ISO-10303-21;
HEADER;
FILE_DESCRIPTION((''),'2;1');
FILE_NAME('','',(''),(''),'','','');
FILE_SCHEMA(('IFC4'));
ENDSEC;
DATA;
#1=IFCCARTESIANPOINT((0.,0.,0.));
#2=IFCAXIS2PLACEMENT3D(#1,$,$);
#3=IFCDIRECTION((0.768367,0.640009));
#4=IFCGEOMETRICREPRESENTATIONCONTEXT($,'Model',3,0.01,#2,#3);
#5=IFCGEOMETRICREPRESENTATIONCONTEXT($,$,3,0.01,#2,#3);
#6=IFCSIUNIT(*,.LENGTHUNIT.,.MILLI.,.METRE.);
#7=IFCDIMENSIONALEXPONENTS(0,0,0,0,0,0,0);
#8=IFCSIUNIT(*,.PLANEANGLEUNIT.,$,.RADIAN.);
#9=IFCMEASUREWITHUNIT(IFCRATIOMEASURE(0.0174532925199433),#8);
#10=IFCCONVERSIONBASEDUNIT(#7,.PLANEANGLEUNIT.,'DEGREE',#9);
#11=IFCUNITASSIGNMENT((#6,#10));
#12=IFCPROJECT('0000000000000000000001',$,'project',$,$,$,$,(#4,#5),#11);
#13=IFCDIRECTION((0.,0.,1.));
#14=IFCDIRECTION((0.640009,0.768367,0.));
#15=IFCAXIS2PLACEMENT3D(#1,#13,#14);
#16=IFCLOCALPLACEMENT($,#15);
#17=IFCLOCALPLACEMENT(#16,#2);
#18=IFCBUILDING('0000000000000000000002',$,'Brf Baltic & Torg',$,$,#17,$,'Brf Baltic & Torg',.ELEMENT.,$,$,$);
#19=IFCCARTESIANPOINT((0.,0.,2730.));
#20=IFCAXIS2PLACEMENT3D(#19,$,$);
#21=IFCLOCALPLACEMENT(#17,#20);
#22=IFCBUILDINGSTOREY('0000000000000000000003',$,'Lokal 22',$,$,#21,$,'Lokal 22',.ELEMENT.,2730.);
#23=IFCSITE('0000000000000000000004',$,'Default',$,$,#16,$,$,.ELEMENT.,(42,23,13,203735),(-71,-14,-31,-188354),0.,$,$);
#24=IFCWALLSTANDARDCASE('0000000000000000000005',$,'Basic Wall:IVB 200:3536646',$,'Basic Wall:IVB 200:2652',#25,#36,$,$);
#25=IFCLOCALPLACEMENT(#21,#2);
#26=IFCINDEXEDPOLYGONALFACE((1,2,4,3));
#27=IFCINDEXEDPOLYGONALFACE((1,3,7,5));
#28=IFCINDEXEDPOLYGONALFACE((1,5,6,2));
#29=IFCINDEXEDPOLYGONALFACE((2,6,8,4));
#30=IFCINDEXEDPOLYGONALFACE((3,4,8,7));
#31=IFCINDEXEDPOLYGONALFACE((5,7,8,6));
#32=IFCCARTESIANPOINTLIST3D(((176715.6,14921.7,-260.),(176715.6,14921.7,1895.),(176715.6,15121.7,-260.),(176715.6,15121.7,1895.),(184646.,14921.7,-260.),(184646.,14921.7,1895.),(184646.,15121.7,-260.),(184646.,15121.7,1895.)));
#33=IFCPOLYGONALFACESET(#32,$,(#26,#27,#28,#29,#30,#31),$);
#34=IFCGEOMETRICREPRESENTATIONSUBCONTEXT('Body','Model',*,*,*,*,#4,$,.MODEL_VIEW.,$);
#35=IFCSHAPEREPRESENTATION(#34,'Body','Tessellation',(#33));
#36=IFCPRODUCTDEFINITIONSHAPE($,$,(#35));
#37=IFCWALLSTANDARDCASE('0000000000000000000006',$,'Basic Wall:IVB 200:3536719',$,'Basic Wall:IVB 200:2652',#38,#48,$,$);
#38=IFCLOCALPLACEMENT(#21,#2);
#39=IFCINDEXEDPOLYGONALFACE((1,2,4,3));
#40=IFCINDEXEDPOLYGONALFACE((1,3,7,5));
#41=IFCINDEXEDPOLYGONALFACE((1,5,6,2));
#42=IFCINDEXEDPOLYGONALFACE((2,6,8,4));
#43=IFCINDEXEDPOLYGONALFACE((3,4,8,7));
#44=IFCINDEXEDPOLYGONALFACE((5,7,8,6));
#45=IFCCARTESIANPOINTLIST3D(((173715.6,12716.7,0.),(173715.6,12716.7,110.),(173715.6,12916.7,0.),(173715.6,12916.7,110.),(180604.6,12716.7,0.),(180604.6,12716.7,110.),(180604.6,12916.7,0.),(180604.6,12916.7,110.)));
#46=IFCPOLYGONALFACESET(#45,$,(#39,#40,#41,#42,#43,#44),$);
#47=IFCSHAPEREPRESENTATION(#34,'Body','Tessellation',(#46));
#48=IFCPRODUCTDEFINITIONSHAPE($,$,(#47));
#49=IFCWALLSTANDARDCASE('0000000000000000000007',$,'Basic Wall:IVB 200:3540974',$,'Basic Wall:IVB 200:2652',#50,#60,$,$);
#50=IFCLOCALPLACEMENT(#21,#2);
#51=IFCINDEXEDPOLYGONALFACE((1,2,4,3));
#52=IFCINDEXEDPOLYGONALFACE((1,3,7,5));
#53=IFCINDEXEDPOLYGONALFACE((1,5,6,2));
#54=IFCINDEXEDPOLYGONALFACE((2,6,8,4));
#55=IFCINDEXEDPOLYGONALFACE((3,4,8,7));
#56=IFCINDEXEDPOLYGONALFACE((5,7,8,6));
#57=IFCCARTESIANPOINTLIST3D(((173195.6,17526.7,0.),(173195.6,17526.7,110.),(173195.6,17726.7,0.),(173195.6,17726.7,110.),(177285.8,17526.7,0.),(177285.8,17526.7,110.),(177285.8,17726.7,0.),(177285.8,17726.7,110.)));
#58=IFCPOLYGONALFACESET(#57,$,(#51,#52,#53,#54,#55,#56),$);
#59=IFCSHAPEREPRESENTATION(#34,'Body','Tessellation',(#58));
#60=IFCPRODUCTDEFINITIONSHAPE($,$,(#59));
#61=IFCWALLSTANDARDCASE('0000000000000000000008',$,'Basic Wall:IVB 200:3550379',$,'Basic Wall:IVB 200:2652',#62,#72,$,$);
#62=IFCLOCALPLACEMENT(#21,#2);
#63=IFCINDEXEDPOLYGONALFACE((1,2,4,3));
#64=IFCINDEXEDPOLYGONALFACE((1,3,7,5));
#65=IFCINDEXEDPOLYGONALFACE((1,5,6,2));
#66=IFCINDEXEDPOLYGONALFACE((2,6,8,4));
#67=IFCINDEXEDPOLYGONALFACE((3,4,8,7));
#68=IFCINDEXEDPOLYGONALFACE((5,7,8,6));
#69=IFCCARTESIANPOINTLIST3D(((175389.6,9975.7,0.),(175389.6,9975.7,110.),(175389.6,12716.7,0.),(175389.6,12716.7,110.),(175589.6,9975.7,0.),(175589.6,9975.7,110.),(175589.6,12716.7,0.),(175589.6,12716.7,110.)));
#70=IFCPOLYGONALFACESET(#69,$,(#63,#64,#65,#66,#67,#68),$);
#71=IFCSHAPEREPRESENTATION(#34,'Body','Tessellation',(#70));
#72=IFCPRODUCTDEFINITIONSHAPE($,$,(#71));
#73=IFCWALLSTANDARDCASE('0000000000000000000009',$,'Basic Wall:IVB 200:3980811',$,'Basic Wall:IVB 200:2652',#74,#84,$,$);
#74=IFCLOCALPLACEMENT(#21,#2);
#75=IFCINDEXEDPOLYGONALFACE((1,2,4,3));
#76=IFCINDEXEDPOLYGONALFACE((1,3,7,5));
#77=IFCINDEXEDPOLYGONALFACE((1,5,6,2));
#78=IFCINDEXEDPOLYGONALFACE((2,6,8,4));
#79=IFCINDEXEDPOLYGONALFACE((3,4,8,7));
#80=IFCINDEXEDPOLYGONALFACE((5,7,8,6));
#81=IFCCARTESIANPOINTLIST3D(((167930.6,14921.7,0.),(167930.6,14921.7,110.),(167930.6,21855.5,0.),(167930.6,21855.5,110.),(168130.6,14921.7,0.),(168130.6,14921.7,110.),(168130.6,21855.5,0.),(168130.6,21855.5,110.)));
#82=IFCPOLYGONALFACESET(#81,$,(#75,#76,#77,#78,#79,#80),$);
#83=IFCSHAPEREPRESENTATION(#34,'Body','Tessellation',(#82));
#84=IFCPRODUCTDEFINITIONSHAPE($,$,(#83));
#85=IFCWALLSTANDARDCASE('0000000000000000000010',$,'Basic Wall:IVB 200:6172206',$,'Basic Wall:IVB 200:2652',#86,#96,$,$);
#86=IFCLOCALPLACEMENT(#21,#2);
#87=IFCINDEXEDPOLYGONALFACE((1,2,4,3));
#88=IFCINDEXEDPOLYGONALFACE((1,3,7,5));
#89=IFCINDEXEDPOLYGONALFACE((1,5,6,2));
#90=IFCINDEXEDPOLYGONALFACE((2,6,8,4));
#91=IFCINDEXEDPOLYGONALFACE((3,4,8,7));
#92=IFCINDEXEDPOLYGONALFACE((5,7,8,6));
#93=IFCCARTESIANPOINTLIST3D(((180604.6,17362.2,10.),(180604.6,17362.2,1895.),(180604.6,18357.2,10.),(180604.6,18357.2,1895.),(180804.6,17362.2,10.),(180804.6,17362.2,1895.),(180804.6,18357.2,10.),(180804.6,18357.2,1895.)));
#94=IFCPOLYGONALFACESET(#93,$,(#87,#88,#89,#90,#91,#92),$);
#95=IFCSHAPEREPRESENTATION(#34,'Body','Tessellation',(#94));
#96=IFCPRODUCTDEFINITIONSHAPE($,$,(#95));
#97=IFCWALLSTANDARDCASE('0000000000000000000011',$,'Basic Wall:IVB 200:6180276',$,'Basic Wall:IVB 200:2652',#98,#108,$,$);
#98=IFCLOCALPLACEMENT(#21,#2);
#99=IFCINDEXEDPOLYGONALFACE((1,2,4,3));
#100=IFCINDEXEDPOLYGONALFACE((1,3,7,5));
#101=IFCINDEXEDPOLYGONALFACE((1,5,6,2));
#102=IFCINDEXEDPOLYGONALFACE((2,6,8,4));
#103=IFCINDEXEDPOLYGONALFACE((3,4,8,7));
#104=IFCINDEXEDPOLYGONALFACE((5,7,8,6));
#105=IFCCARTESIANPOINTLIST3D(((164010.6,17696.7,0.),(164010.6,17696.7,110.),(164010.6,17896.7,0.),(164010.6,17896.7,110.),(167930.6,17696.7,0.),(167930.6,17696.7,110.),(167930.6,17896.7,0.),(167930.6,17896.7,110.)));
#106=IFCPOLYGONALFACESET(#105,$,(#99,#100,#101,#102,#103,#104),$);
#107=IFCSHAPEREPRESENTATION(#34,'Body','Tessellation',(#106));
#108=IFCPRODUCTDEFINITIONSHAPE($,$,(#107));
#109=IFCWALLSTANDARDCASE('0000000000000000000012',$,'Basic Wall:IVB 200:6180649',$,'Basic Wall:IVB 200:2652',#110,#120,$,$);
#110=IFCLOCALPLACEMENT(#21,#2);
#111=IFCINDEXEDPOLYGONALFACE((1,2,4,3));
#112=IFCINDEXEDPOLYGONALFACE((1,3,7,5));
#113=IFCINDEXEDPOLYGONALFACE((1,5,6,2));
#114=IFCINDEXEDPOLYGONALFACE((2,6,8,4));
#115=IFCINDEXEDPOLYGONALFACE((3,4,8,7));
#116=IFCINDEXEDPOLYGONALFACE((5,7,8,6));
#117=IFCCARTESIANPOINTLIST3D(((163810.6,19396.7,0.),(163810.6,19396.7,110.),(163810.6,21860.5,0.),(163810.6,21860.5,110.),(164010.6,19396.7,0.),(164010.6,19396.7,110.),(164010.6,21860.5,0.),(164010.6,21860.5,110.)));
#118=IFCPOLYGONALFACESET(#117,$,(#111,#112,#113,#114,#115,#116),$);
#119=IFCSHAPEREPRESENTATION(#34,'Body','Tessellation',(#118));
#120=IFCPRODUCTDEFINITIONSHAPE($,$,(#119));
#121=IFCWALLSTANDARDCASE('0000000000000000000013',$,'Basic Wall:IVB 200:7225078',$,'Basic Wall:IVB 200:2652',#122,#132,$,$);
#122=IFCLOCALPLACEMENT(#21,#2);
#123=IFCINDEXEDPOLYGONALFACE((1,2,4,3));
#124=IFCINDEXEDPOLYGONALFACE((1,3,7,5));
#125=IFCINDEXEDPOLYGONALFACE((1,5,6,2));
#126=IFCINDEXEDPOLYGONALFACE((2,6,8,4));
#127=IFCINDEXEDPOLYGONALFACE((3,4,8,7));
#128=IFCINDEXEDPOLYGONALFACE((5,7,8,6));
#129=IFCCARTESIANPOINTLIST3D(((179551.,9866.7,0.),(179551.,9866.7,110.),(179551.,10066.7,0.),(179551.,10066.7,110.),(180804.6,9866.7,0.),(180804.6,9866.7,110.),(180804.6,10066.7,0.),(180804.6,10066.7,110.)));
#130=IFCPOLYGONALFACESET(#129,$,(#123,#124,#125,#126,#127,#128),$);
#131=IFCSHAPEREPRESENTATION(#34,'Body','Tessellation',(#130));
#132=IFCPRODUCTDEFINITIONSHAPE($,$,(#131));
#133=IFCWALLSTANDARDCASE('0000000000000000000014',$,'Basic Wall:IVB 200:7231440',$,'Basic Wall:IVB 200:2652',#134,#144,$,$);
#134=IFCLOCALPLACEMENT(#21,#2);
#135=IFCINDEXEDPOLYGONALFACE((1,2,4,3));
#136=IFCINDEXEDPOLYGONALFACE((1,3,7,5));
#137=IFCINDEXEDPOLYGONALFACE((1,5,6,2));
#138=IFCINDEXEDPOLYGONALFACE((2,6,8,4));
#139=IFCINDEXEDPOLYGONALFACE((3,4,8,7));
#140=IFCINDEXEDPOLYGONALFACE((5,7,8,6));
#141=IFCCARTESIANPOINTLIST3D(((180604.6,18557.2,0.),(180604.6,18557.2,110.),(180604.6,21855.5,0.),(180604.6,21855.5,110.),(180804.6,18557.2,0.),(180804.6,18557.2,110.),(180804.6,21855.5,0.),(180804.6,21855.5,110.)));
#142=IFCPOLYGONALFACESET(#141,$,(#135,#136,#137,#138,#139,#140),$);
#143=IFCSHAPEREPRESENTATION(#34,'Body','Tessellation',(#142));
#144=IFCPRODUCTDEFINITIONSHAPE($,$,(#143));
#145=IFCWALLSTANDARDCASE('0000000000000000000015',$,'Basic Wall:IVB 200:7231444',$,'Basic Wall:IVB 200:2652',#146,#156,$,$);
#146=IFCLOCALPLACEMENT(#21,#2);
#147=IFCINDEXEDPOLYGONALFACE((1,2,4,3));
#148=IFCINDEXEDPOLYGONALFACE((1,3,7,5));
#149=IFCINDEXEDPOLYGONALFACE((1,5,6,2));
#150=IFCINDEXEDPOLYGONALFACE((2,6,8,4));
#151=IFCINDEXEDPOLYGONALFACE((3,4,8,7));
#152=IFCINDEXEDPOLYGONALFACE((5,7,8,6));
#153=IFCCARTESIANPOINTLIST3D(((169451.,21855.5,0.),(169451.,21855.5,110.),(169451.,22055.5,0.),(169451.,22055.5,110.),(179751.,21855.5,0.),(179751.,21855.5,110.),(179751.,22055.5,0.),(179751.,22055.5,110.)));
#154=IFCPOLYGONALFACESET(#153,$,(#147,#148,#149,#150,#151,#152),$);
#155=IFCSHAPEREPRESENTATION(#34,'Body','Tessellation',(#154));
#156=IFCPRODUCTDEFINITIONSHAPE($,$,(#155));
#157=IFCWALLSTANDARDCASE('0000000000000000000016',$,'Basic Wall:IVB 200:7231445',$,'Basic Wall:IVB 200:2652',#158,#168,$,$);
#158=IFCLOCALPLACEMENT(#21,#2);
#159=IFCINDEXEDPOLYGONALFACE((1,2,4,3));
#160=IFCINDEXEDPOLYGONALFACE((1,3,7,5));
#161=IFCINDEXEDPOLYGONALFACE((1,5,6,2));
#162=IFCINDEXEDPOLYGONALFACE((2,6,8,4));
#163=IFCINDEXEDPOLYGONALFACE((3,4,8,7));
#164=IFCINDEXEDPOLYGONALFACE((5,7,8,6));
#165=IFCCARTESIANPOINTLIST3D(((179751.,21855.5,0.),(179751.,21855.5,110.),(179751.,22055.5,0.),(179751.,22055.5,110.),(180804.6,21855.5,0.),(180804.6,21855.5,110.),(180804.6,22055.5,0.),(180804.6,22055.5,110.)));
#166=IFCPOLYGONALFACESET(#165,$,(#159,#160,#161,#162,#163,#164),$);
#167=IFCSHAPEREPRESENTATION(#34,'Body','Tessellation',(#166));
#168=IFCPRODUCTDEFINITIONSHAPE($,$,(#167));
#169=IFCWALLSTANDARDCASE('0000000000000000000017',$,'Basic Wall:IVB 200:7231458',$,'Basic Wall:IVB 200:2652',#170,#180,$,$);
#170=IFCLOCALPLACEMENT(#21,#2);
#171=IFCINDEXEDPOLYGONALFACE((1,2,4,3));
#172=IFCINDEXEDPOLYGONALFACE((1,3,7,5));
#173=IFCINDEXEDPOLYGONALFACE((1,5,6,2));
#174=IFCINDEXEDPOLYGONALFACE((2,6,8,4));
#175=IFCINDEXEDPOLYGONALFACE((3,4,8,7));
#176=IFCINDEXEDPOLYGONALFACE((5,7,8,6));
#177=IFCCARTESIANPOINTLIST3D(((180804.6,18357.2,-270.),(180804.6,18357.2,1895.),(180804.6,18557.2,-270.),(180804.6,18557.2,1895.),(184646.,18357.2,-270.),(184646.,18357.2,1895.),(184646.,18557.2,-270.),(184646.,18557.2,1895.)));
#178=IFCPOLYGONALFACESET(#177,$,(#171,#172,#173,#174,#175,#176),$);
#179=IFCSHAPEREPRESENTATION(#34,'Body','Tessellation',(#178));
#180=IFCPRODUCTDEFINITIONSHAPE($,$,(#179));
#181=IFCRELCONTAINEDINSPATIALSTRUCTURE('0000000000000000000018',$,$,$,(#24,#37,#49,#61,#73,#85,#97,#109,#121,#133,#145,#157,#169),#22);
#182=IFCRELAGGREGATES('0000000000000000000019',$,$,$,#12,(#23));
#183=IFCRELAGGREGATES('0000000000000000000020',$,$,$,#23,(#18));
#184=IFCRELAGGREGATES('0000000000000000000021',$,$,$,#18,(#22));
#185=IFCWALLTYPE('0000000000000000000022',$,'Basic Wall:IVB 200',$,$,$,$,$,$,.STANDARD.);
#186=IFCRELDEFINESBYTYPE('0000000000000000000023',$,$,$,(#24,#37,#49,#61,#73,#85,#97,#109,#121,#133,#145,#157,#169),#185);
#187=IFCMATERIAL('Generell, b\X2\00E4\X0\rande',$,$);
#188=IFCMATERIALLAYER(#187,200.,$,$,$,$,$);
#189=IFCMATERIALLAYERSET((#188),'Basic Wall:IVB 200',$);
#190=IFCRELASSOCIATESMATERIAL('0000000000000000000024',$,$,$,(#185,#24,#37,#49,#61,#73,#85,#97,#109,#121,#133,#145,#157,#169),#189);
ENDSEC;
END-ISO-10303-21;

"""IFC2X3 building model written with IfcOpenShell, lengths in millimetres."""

from ifc_helpers import new_model, entity, si_unit, converted_unit, direction, frame, frame_2d, origin, place, context, subcontext, project, spatial, rectangle, extrude, clip, halfspace, material, layer, layer_set, layer_usage, type_object, element, save


model = new_model("IFC2X3")

# Units and contexts
model_context = context("Model", 3, precision=0.01, world=origin(), true_north=direction((0.768367, 0.640009)))
context_of_model = context(None, 3, precision=0.01, world=origin(), true_north=direction((0.768367, 0.640009)))
body_context = subcontext(model_context, "Body", "Model", "MODEL_VIEW")
ifc_project = project(units=[si_unit("LENGTHUNIT", "METRE", prefix="MILLI"), converted_unit("PLANEANGLEUNIT", "DEGREE", entity("IfcRatioMeasure", 0.0174532925199433), si_unit("PLANEANGLEUNIT", "RADIAN"), dimensions=[0, 0, 0, 0, 0, 0, 0])], contexts=[model_context, context_of_model])

# Site, building, storey
site_placement = place(None, frame((0.0, 0.0, 0.0), z_axis=(0.0, 0.0, 1.0), x_axis=(0.640009, 0.768367, 0.0)))
site = spatial("IfcSite", under=ifc_project, at=site_placement, Name="Default", CompositionType="ELEMENT", RefLatitude=(42, 23, 13, 203735), RefLongitude=(-71, -14, -31, -188354), RefElevation=0.0)
building_placement = place(site_placement, origin())
building = spatial("IfcBuilding", under=site, at=building_placement, Name="Brf Baltic & Torg", LongName="Brf Baltic & Torg", CompositionType="ELEMENT")
storey_placement = place(building_placement, frame((0.0, 0.0, 2730.0)))
storey = spatial("IfcBuildingStorey", under=building, at=storey_placement, Name="Lokal 22", LongName="Lokal 22", CompositionType="ELEMENT", Elevation=2730.0)

# Shared definitions
ifc_material = material(Name="Generell, bärande")
ifc_layer = layer(ifc_material, 200.0)
ifc_layer_set = layer_set([ifc_layer], Name="Basic Wall:IVB 200")
wall_type = type_object("IfcWallType", Name="Basic Wall:IVB 200", PredefinedType="STANDARD", material=ifc_layer_set)

# Walls
ifc_layer_usage_1 = layer_usage(ifc_layer_set, "AXIS2", "POSITIVE", -100.0)
wall_1_placement = place(storey_placement, frame((176715.6, 15021.7, -260.0)))
element("IfcWallStandardCase", 1, at=wall_1_placement, inside=storey, type_object=wall_type, material=ifc_layer_usage_1, Name="Basic Wall:IVB 200:3536646", ObjectType="Basic Wall:IVB 200:2652", context=body_context, shape_type="SweptSolid", body=[
    extrude(rectangle(XDim=7930.4, YDim=200.0, at=frame_2d((3965.2, 0.0), x_axis=(-1.0, 0.0))), origin(), (0.0, 0.0, 1.0), 2155.0),
])
ifc_layer_usage_2 = layer_usage(ifc_layer_set, "AXIS2", "NEGATIVE", 100.0)
wall_2_placement = place(storey_placement, frame((173715.6, 12816.7, 0.0)))
element("IfcWallStandardCase", 2, at=wall_2_placement, inside=storey, type_object=wall_type, material=ifc_layer_usage_2, Name="Basic Wall:IVB 200:3536719", ObjectType="Basic Wall:IVB 200:2652", context=body_context, shape_type="Clipping", body=[
    clip(extrude(rectangle(XDim=6889.0, YDim=200.0, at=frame_2d((3444.5, 0.0), x_axis=(-1.0, 0.0))), origin(), (0.0, 0.0, 1.0), 110.0), halfspace(frame((0.0, 0.0, -1080.0)), True)),
])
ifc_layer_usage_3 = layer_usage(ifc_layer_set, "AXIS2", "NEGATIVE", 100.0)
wall_3_placement = place(storey_placement, frame((173195.6, 17626.7, 0.0)))
element("IfcWallStandardCase", 3, at=wall_3_placement, inside=storey, type_object=wall_type, material=ifc_layer_usage_3, Name="Basic Wall:IVB 200:3540974", ObjectType="Basic Wall:IVB 200:2652", context=body_context, shape_type="Clipping", body=[
    clip(extrude(rectangle(XDim=4090.2, YDim=200.0, at=frame_2d((2045.1, 0.0), x_axis=(-1.0, 0.0))), origin(), (0.0, 0.0, 1.0), 110.0), halfspace(frame((0.0, 0.0, -1080.0)), True)),
])
ifc_layer_usage_4 = layer_usage(ifc_layer_set, "AXIS2", "POSITIVE", -100.0)
wall_4_placement = place(storey_placement, frame((175489.6, 9975.7, 0.0), z_axis=(0.0, 0.0, 1.0), x_axis=(0.0, 1.0, 0.0)))
element("IfcWallStandardCase", 4, at=wall_4_placement, inside=storey, type_object=wall_type, material=ifc_layer_usage_4, Name="Basic Wall:IVB 200:3550379", ObjectType="Basic Wall:IVB 200:2652", context=body_context, shape_type="Clipping", body=[
    clip(extrude(rectangle(XDim=2741.0, YDim=200.0, at=frame_2d((1370.5, 0.0), x_axis=(-1.0, 0.0))), origin(), (0.0, 0.0, 1.0), 110.0), halfspace(frame((0.0, 0.0, -1080.0)), True)),
])

# Walls
ifc_layer_usage_5 = layer_usage(ifc_layer_set, "AXIS2", "NEGATIVE", 100.0)
wall_5_placement = place(storey_placement, frame((168030.6, 21855.5, 0.0), z_axis=(0.0, 0.0, 1.0), x_axis=(0.0, -1.0, 0.0)))
element("IfcWallStandardCase", 5, at=wall_5_placement, inside=storey, type_object=wall_type, material=ifc_layer_usage_5, Name="Basic Wall:IVB 200:3980811", ObjectType="Basic Wall:IVB 200:2652", context=body_context, shape_type="Clipping", body=[
    clip(extrude(rectangle(XDim=6933.7, YDim=200.0, at=frame_2d((3466.9, 0.0), x_axis=(-1.0, 0.0))), origin(), (0.0, 0.0, 1.0), 110.0), halfspace(frame((0.0, 0.0, -1080.0)), True)),
])
ifc_layer_usage_6 = layer_usage(ifc_layer_set, "AXIS2", "POSITIVE", -100.0)
wall_6_placement = place(storey_placement, frame((180704.6, 17362.2, 10.0), z_axis=(0.0, 0.0, 1.0), x_axis=(0.0, 1.0, 0.0)))
element("IfcWallStandardCase", 6, at=wall_6_placement, inside=storey, type_object=wall_type, material=ifc_layer_usage_6, Name="Basic Wall:IVB 200:6172206", ObjectType="Basic Wall:IVB 200:2652", context=body_context, shape_type="SweptSolid", body=[
    extrude(rectangle(XDim=995.0, YDim=200.0, at=frame_2d((497.5, 0.0), x_axis=(-1.0, 0.0))), origin(), (0.0, 0.0, 1.0), 1885.0),
])
ifc_layer_usage_7 = layer_usage(ifc_layer_set, "AXIS2", "POSITIVE", -100.0)
wall_7_placement = place(storey_placement, frame((167930.6, 17796.7, 0.0), z_axis=(0.0, 0.0, 1.0), x_axis=(-1.0, 0.0, 0.0)))
element("IfcWallStandardCase", 7, at=wall_7_placement, inside=storey, type_object=wall_type, material=ifc_layer_usage_7, Name="Basic Wall:IVB 200:6180276", ObjectType="Basic Wall:IVB 200:2652", context=body_context, shape_type="Clipping", body=[
    clip(extrude(rectangle(XDim=3920.0, YDim=200.0, at=frame_2d((1960.0, 0.0), x_axis=(-1.0, 0.0))), origin(), (0.0, 0.0, 1.0), 110.0), halfspace(frame((0.0, 0.0, -1080.0)), True)),
])
ifc_layer_usage_8 = layer_usage(ifc_layer_set, "AXIS2", "NEGATIVE", 100.0)
wall_8_placement = place(storey_placement, frame((163910.6, 19396.7, 0.0), z_axis=(0.0, 0.0, 1.0), x_axis=(0.0, 1.0, 0.0)))
element("IfcWallStandardCase", 8, at=wall_8_placement, inside=storey, type_object=wall_type, material=ifc_layer_usage_8, Name="Basic Wall:IVB 200:6180649", ObjectType="Basic Wall:IVB 200:2652", context=body_context, shape_type="Clipping", body=[
    clip(extrude(rectangle(XDim=2463.7, YDim=200.0, at=frame_2d((1231.9, 0.0), x_axis=(-1.0, 0.0))), origin(), (0.0, 0.0, 1.0), 110.0), halfspace(frame((0.0, 0.0, -1080.0)), True)),
])
ifc_layer_usage_9 = layer_usage(ifc_layer_set, "AXIS2", "NEGATIVE", 100.0)
wall_9_placement = place(storey_placement, frame((180804.6, 9966.7, 0.0), z_axis=(0.0, 0.0, 1.0), x_axis=(-1.0, 0.0, 0.0)))
element("IfcWallStandardCase", 9, at=wall_9_placement, inside=storey, type_object=wall_type, material=ifc_layer_usage_9, Name="Basic Wall:IVB 200:7225078", ObjectType="Basic Wall:IVB 200:2652", context=body_context, shape_type="Clipping", body=[
    clip(extrude(rectangle(XDim=1253.6, YDim=200.0, at=frame_2d((626.8, 0.0), x_axis=(-1.0, 0.0))), origin(), (0.0, 0.0, 1.0), 110.0), halfspace(frame((0.0, 0.0, -1080.0)), True)),
])
ifc_layer_usage_10 = layer_usage(ifc_layer_set, "AXIS2", "POSITIVE", -100.0)
wall_10_placement = place(storey_placement, frame((180704.6, 18557.2, 0.0), z_axis=(0.0, 0.0, 1.0), x_axis=(0.0, 1.0, 0.0)))
element("IfcWallStandardCase", 10, at=wall_10_placement, inside=storey, type_object=wall_type, material=ifc_layer_usage_10, Name="Basic Wall:IVB 200:7231440", ObjectType="Basic Wall:IVB 200:2652", context=body_context, shape_type="Clipping", body=[
    clip(extrude(rectangle(XDim=3298.3, YDim=200.0, at=frame_2d((1649.1, 0.0), x_axis=(-1.0, 0.0))), origin(), (0.0, 0.0, 1.0), 110.0), halfspace(frame((0.0, 0.0, -1080.0)), True)),
])
ifc_layer_usage_11 = layer_usage(ifc_layer_set, "AXIS2", "NEGATIVE", 100.0)
wall_11_placement = place(storey_placement, frame((169451.0, 21955.5, 0.0)))
element("IfcWallStandardCase", 11, at=wall_11_placement, inside=storey, type_object=wall_type, material=ifc_layer_usage_11, Name="Basic Wall:IVB 200:7231444", ObjectType="Basic Wall:IVB 200:2652", context=body_context, shape_type="Clipping", body=[
    clip(extrude(rectangle(XDim=10300.0, YDim=200.0, at=frame_2d((5150.0, 0.0), x_axis=(-1.0, 0.0))), origin(), (0.0, 0.0, 1.0), 110.0), halfspace(frame((0.0, 0.0, -1080.0)), True)),
])
ifc_layer_usage_12 = layer_usage(ifc_layer_set, "AXIS2", "NEGATIVE", 100.0)
wall_12_placement = place(storey_placement, frame((179751.0, 21955.5, 0.0)))
element("IfcWallStandardCase", 12, at=wall_12_placement, inside=storey, type_object=wall_type, material=ifc_layer_usage_12, Name="Basic Wall:IVB 200:7231445", ObjectType="Basic Wall:IVB 200:2652", context=body_context, shape_type="Clipping", body=[
    clip(extrude(rectangle(XDim=1053.6, YDim=200.0, at=frame_2d((526.8, 0.0), x_axis=(-1.0, 0.0))), origin(), (0.0, 0.0, 1.0), 110.0), halfspace(frame((0.0, 0.0, -1080.0)), True)),
])
ifc_layer_usage_13 = layer_usage(ifc_layer_set, "AXIS2", "NEGATIVE", 100.0)
wall_13_placement = place(storey_placement, frame((180804.6, 18457.2, -270.0)))
element("IfcWallStandardCase", 13, at=wall_13_placement, inside=storey, type_object=wall_type, material=ifc_layer_usage_13, Name="Basic Wall:IVB 200:7231458", ObjectType="Basic Wall:IVB 200:2652", context=body_context, shape_type="SweptSolid", body=[
    extrude(rectangle(XDim=3841.4, YDim=200.0, at=frame_2d((1920.7, 0.0), x_axis=(-1.0, 0.0))), origin(), (0.0, 0.0, 1.0), 2165.0),
])

save(model, "model.ifc")
